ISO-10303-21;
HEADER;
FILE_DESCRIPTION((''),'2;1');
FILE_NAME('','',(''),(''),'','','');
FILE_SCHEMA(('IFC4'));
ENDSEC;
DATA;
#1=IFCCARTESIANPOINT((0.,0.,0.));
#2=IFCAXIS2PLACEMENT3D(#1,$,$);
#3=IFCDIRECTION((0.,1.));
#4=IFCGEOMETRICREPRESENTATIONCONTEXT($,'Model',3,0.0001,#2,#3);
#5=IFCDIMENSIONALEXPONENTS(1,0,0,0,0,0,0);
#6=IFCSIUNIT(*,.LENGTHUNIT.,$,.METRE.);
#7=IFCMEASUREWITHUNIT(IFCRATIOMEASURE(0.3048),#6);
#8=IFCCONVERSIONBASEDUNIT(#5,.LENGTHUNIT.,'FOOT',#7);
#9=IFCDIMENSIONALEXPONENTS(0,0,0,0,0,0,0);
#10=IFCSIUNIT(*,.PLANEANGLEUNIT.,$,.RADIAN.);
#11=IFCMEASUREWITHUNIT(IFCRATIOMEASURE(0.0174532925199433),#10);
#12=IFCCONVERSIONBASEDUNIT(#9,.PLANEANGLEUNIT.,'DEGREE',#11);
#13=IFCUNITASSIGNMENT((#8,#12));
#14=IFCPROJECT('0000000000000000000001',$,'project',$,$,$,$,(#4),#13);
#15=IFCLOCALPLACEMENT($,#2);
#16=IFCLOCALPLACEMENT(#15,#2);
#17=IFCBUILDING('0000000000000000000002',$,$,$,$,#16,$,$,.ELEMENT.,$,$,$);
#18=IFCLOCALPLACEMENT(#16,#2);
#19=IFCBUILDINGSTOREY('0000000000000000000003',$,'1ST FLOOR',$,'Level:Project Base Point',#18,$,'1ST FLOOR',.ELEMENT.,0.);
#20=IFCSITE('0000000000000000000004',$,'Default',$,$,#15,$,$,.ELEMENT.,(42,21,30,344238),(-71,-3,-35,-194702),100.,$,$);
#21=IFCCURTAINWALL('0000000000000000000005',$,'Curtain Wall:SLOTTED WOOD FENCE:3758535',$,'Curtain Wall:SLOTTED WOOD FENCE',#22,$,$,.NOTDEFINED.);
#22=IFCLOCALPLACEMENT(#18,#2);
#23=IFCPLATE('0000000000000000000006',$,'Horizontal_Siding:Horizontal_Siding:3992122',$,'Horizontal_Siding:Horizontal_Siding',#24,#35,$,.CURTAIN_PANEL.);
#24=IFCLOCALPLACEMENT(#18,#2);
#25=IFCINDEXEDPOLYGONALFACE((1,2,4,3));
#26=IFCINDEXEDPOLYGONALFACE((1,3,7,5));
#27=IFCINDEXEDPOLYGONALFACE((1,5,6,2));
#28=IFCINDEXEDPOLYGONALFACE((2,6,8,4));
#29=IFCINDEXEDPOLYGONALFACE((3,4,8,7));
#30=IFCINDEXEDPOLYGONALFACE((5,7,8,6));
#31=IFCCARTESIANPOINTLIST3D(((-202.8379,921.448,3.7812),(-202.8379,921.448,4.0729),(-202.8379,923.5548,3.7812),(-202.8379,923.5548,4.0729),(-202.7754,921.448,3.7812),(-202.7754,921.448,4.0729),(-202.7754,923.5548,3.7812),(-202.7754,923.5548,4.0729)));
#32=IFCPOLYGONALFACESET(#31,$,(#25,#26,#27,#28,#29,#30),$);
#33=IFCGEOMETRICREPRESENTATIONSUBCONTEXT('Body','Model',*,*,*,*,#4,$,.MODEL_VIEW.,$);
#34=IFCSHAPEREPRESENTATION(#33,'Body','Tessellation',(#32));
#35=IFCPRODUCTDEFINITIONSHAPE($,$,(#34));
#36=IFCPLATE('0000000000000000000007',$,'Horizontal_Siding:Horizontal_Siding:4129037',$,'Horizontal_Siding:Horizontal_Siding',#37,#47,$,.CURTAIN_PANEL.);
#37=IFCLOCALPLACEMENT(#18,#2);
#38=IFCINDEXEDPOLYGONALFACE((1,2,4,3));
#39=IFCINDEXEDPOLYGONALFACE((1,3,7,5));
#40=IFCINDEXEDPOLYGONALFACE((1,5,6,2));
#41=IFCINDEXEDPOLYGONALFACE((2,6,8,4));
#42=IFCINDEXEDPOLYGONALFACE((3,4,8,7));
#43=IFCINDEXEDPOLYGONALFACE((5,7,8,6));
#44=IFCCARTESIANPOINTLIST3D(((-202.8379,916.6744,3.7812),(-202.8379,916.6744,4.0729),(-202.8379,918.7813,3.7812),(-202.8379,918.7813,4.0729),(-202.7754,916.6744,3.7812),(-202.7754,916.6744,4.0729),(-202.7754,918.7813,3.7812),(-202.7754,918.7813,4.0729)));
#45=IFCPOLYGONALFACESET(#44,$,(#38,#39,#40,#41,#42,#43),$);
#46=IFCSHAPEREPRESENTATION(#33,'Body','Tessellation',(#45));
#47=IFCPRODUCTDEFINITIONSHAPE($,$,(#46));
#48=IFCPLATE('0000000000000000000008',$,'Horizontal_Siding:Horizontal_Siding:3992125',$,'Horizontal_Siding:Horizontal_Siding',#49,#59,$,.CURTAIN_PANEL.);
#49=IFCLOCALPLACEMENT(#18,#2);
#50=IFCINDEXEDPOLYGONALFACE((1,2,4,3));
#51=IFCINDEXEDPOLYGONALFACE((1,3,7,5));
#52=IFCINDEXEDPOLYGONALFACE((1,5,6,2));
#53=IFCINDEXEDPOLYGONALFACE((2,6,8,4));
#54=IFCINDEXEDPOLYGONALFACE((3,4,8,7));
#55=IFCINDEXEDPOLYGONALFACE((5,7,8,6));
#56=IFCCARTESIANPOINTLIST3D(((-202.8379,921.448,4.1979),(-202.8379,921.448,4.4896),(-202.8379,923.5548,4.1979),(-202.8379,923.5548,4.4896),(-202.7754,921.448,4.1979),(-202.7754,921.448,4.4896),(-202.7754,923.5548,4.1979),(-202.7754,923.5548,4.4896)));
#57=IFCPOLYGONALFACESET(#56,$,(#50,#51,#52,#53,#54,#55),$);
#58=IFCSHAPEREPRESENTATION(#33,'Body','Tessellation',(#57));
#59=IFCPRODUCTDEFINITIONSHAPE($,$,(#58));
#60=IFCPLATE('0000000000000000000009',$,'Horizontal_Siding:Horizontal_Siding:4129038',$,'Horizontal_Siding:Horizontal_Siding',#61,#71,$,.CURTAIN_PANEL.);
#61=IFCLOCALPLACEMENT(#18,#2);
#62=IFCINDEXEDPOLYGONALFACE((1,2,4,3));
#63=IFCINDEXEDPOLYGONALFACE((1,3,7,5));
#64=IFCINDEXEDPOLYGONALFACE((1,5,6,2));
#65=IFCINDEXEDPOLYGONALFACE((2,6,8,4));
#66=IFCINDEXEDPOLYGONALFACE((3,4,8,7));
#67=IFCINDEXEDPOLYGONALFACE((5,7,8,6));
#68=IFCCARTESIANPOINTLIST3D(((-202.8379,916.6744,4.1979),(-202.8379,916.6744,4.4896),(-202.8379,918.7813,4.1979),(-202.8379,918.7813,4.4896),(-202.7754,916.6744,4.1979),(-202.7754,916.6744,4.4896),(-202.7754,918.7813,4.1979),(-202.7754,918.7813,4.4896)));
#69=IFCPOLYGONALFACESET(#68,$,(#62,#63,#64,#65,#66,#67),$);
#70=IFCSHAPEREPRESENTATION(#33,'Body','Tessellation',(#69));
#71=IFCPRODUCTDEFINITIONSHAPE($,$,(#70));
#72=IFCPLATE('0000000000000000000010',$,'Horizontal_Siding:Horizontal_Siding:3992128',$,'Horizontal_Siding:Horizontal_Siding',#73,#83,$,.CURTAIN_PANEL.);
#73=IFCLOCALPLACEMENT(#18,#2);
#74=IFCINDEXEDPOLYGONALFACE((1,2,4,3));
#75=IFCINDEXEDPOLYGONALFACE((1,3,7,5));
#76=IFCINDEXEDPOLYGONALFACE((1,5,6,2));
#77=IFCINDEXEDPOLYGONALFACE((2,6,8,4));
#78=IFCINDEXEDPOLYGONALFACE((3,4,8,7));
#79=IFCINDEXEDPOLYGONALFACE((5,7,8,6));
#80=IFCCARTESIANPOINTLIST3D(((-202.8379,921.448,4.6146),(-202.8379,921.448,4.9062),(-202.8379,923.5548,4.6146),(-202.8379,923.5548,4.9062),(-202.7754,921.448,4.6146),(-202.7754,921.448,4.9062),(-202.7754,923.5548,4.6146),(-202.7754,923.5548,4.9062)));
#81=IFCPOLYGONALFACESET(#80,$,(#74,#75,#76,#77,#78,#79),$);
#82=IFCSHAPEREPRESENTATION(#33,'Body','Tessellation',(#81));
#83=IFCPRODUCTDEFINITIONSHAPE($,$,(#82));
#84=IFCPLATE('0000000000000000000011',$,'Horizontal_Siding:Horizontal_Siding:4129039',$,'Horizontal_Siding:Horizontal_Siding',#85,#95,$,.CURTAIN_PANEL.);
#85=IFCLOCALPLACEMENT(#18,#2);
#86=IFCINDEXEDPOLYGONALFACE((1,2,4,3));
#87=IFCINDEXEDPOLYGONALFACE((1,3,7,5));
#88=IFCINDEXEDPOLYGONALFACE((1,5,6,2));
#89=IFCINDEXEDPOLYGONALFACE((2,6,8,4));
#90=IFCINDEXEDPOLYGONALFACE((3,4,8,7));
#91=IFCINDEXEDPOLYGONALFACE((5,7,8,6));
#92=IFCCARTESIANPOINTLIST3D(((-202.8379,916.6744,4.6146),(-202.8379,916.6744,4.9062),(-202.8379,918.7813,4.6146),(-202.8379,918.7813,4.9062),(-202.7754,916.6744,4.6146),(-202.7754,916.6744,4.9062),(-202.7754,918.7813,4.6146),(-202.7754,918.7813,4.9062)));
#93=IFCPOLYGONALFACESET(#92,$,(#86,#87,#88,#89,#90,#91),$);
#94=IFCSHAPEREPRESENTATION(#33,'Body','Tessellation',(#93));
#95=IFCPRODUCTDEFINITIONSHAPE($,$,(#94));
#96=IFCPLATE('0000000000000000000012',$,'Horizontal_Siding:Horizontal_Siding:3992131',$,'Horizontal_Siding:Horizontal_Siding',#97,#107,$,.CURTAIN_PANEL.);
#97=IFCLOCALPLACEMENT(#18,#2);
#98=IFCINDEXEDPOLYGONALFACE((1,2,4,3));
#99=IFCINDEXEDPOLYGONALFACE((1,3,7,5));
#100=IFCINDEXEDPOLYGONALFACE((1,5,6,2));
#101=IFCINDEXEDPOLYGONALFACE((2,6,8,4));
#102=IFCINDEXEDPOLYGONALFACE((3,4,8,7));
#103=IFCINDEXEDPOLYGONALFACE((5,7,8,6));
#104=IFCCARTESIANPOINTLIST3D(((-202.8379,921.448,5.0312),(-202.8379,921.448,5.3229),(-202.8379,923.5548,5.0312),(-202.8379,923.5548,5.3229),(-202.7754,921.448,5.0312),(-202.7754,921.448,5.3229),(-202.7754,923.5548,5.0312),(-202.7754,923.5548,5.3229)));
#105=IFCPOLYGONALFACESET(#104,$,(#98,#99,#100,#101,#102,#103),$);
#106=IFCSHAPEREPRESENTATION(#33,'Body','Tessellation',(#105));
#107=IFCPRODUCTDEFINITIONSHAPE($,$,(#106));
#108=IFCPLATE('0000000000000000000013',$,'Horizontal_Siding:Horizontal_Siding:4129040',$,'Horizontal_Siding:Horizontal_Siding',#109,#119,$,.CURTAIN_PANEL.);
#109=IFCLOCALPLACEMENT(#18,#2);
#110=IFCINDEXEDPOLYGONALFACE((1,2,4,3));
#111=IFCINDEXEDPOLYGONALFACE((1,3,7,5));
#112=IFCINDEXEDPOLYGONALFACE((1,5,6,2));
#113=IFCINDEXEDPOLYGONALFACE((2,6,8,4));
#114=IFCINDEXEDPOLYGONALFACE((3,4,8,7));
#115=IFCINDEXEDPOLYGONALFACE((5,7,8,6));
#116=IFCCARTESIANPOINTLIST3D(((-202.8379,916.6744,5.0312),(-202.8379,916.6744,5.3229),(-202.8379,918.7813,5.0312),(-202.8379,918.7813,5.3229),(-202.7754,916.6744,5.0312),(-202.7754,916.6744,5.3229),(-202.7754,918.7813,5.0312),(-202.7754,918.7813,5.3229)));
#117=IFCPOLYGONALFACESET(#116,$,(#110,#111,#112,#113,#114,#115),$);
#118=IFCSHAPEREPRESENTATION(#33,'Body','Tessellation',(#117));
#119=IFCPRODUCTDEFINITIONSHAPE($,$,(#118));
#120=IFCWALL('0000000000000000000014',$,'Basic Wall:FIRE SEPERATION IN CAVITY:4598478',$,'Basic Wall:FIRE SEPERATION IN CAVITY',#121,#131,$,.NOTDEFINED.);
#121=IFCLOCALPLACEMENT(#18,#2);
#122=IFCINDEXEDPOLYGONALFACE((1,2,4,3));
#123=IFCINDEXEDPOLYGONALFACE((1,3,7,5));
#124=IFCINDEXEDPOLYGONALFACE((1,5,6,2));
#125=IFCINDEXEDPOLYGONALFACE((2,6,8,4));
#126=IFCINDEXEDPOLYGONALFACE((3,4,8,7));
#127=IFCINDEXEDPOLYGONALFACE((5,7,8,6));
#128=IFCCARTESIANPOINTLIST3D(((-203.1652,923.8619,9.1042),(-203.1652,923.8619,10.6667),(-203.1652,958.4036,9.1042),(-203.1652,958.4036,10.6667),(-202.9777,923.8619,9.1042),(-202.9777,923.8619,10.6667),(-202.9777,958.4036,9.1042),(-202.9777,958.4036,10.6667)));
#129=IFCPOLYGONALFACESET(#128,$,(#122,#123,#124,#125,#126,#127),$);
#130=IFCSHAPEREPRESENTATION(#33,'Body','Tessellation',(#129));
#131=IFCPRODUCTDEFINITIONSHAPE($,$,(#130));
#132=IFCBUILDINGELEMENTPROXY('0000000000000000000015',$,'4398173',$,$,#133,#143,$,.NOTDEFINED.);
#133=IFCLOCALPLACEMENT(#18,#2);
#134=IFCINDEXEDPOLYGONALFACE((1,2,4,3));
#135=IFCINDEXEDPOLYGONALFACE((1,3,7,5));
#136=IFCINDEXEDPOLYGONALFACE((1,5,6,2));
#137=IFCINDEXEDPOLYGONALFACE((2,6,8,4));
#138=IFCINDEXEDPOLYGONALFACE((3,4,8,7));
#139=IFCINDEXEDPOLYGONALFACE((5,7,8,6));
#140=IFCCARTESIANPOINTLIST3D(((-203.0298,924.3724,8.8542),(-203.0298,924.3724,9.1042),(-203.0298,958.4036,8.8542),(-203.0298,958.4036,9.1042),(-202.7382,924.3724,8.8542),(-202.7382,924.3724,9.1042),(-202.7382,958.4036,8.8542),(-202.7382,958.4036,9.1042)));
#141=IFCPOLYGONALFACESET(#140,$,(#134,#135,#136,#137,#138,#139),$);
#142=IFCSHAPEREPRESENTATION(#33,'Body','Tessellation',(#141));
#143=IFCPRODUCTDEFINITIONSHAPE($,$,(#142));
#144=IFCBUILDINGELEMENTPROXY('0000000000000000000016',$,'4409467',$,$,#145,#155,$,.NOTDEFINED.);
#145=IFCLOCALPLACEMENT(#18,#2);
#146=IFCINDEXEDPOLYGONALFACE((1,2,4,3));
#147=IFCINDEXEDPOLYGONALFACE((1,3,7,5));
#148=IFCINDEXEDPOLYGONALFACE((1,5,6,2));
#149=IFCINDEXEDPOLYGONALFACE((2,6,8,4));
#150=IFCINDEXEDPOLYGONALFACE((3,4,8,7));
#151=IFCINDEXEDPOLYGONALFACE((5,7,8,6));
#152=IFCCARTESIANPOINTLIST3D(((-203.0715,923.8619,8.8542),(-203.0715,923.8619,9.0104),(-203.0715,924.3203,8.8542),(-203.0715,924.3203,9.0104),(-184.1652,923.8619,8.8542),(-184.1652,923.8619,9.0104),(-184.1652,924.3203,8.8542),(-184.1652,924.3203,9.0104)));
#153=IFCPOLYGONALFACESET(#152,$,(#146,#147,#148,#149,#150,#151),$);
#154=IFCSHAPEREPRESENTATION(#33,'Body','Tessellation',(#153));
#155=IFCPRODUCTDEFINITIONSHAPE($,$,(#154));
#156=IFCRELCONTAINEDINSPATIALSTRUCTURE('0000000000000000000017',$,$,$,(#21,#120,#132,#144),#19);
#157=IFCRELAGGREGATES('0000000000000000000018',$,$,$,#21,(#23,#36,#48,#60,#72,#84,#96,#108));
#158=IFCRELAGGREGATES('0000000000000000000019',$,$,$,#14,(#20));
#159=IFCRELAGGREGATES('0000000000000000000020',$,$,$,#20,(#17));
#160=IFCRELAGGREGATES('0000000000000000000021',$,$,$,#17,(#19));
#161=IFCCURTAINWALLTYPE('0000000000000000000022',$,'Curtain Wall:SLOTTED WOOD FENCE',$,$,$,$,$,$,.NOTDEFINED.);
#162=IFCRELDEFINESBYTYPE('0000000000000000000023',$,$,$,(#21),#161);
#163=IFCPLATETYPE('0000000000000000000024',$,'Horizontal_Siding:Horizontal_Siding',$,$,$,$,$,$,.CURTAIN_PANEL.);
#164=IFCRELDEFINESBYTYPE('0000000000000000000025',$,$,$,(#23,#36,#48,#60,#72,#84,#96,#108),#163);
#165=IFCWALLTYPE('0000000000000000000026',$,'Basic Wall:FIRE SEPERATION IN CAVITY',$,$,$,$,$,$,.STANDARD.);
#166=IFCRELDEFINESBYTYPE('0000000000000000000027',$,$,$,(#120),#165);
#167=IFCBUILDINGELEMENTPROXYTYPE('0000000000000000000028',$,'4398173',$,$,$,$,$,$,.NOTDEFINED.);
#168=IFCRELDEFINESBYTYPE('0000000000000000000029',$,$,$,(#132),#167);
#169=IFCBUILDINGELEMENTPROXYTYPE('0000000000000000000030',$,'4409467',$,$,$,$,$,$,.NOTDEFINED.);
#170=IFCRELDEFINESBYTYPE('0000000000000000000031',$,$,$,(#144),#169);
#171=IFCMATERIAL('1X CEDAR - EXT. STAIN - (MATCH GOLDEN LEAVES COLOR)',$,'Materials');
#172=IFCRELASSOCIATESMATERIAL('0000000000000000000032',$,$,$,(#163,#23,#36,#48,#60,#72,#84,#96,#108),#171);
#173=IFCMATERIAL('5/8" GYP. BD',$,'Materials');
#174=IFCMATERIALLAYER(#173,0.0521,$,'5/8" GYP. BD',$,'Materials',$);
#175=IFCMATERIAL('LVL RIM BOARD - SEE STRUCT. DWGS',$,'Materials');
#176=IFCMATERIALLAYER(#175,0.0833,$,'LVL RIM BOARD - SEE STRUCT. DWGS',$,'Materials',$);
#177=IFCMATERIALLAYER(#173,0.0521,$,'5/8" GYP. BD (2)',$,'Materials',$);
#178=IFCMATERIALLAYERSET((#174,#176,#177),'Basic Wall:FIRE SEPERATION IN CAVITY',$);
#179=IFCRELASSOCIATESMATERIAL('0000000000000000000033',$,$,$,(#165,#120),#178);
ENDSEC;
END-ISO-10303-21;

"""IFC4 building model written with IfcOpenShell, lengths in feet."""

from ifc_helpers import new_model, entity, si_unit, converted_unit, direction, frame, frame_2d, origin, origin_2d_with_axis, place, context, subcontext, project, spatial, rectangle, extrude, source, transform, mapped, material, layer, layer_set, layer_usage, type_object, type_shapes, element, aggregate, save


model = new_model("IFC4")

# Units and contexts
model_context = context("Model", 3, precision=0.0001, world=origin(), true_north=direction((0.0, 1.0)))
body_context = subcontext(model_context, "Body", "Model", "MODEL_VIEW")
ifc_project = project(units=[converted_unit("LENGTHUNIT", "FOOT", entity("IfcRatioMeasure", 0.3048), si_unit("LENGTHUNIT", "METRE"), dimensions=[1, 0, 0, 0, 0, 0, 0]), converted_unit("PLANEANGLEUNIT", "DEGREE", entity("IfcRatioMeasure", 0.0174532925199433), si_unit("PLANEANGLEUNIT", "RADIAN"), dimensions=[0, 0, 0, 0, 0, 0, 0])], contexts=[model_context])

# Site, building, storey
site_placement = place(None, origin())
site = spatial("IfcSite", under=ifc_project, at=site_placement, Name="Default", CompositionType="ELEMENT", RefLatitude=(42, 21, 30, 344238), RefLongitude=(-71, -3, -35, -194702), RefElevation=100.0)
building_placement = place(site_placement, origin())
building = spatial("IfcBuilding", under=site, at=building_placement, CompositionType="ELEMENT")
storey_placement = place(building_placement, origin())
storey = spatial("IfcBuildingStorey", under=building, at=storey_placement, Name="1ST FLOOR", ObjectType="Level:Project Base Point", LongName="1ST FLOOR", CompositionType="ELEMENT", Elevation=0.0)

# Curtain wall, plates
curtain_wall_type = type_object("IfcCurtainWallType", Name="Curtain Wall:SLOTTED WOOD FENCE", PredefinedType="NOTDEFINED")
curtain_wall_placement = place(storey_placement, origin())
curtain_wall = element("IfcCurtainWall", 1, at=curtain_wall_placement, inside=storey, type_object=curtain_wall_type, Name="Curtain Wall:SLOTTED WOOD FENCE:3758535", ObjectType="Curtain Wall:SLOTTED WOOD FENCE", PredefinedType="NOTDEFINED")
ifc_material_1 = material(Name="1X CEDAR - EXT. STAIN - (MATCH GOLDEN LEAVES COLOR)", Category="Materials")
plate_type_1 = type_object("IfcPlateType", Name="Horizontal_Siding:Horizontal_Siding", PredefinedType="CURTAIN_PANEL", material=ifc_material_1)
shared_shape_1 = source(origin(), body_context, "Body", "SweptSolid", [
    extrude(rectangle(XDim=0.0625, YDim=2.1069, at=origin_2d_with_axis()), frame((1.0534, 0.0312, 0.0), z_axis=(0.0, 0.0, 1.0), x_axis=(0.0, 1.0, 0.0)), (0.0, 0.0, 1.0), 0.2917),
])
type_shapes(plate_type_1, [shared_shape_1])
plate_1_placement = place(curtain_wall_placement, frame((-202.8379, 923.5548, 3.7812), z_axis=(0.0, 0.0, 1.0), x_axis=(0.0, -1.0, 0.0)))
plate_1 = element("IfcPlate", 2, at=plate_1_placement, type_object=plate_type_1, material=ifc_material_1, Name="Horizontal_Siding:Horizontal_Siding:3992122", ObjectType="Horizontal_Siding:Horizontal_Siding", PredefinedType="CURTAIN_PANEL", context=body_context, shape_type="MappedRepresentation", body=[
    mapped(shared_shape_1, transform((0.0, 0.0, 0.0), scale=1.0)),
])
plate_2_placement = place(curtain_wall_placement, frame((-202.8379, 918.7813, 3.7812), z_axis=(0.0, 0.0, 1.0), x_axis=(0.0, -1.0, 0.0)))
plate_2 = element("IfcPlate", 3, at=plate_2_placement, type_object=plate_type_1, material=ifc_material_1, Name="Horizontal_Siding:Horizontal_Siding:4129037", ObjectType="Horizontal_Siding:Horizontal_Siding", PredefinedType="CURTAIN_PANEL", context=body_context, shape_type="MappedRepresentation", body=[
    mapped(shared_shape_1, transform((0.0, 0.0, 0.0), scale=1.0)),
])
plate_3_placement = place(curtain_wall_placement, frame((-202.8379, 923.5548, 4.1979), z_axis=(0.0, 0.0, 1.0), x_axis=(0.0, -1.0, 0.0)))
plate_3 = element("IfcPlate", 4, at=plate_3_placement, type_object=plate_type_1, material=ifc_material_1, Name="Horizontal_Siding:Horizontal_Siding:3992125", ObjectType="Horizontal_Siding:Horizontal_Siding", PredefinedType="CURTAIN_PANEL", context=body_context, shape_type="MappedRepresentation", body=[
    mapped(shared_shape_1, transform((0.0, 0.0, 0.0), scale=1.0)),
])
plate_4_placement = place(curtain_wall_placement, frame((-202.8379, 918.7813, 4.1979), z_axis=(0.0, 0.0, 1.0), x_axis=(0.0, -1.0, 0.0)))
plate_4 = element("IfcPlate", 5, at=plate_4_placement, type_object=plate_type_1, material=ifc_material_1, Name="Horizontal_Siding:Horizontal_Siding:4129038", ObjectType="Horizontal_Siding:Horizontal_Siding", PredefinedType="CURTAIN_PANEL", context=body_context, shape_type="MappedRepresentation", body=[
    mapped(shared_shape_1, transform((0.0, 0.0, 0.0), scale=1.0)),
])
plate_5_placement = place(curtain_wall_placement, frame((-202.8379, 923.5548, 4.6146), z_axis=(0.0, 0.0, 1.0), x_axis=(0.0, -1.0, 0.0)))
plate_5 = element("IfcPlate", 6, at=plate_5_placement, type_object=plate_type_1, material=ifc_material_1, Name="Horizontal_Siding:Horizontal_Siding:3992128", ObjectType="Horizontal_Siding:Horizontal_Siding", PredefinedType="CURTAIN_PANEL", context=body_context, shape_type="MappedRepresentation", body=[
    mapped(shared_shape_1, transform((0.0, 0.0, 0.0), scale=1.0)),
])
plate_6_placement = place(curtain_wall_placement, frame((-202.8379, 918.7813, 4.6146), z_axis=(0.0, 0.0, 1.0), x_axis=(0.0, -1.0, 0.0)))
plate_6 = element("IfcPlate", 7, at=plate_6_placement, type_object=plate_type_1, material=ifc_material_1, Name="Horizontal_Siding:Horizontal_Siding:4129039", ObjectType="Horizontal_Siding:Horizontal_Siding", PredefinedType="CURTAIN_PANEL", context=body_context, shape_type="MappedRepresentation", body=[
    mapped(shared_shape_1, transform((0.0, 0.0, 0.0), scale=1.0)),
])
plate_7_placement = place(curtain_wall_placement, frame((-202.8379, 923.5548, 5.0312), z_axis=(0.0, 0.0, 1.0), x_axis=(0.0, -1.0, 0.0)))
plate_7 = element("IfcPlate", 8, at=plate_7_placement, type_object=plate_type_1, material=ifc_material_1, Name="Horizontal_Siding:Horizontal_Siding:3992131", ObjectType="Horizontal_Siding:Horizontal_Siding", PredefinedType="CURTAIN_PANEL", context=body_context, shape_type="MappedRepresentation", body=[
    mapped(shared_shape_1, transform((0.0, 0.0, 0.0), scale=1.0)),
])
plate_8_placement = place(curtain_wall_placement, frame((-202.8379, 918.7813, 5.0312), z_axis=(0.0, 0.0, 1.0), x_axis=(0.0, -1.0, 0.0)))
plate_8 = element("IfcPlate", 9, at=plate_8_placement, type_object=plate_type_1, material=ifc_material_1, Name="Horizontal_Siding:Horizontal_Siding:4129040", ObjectType="Horizontal_Siding:Horizontal_Siding", PredefinedType="CURTAIN_PANEL", context=body_context, shape_type="MappedRepresentation", body=[
    mapped(shared_shape_1, transform((0.0, 0.0, 0.0), scale=1.0)),
])
aggregate(curtain_wall, [plate_1, plate_2, plate_3, plate_4, plate_5, plate_6, plate_7, plate_8])

# Wall
ifc_material_2 = material(Name="5/8\" GYP. BD", Category="Materials")
ifc_layer_1 = layer(ifc_material_2, 0.0521, Name="5/8\" GYP. BD", Category="Materials")
ifc_material_3 = material(Name="LVL RIM BOARD - SEE STRUCT. DWGS", Category="Materials")
ifc_layer_2 = layer(ifc_material_3, 0.0833, Name="LVL RIM BOARD - SEE STRUCT. DWGS", Category="Materials")
ifc_layer_3 = layer(ifc_material_2, 0.0521, Name="5/8\" GYP. BD (2)", Category="Materials")
ifc_layer_set = layer_set([ifc_layer_1, ifc_layer_2, ifc_layer_3], Name="Basic Wall:FIRE SEPERATION IN CAVITY")
ifc_layer_usage = layer_usage(ifc_layer_set, "AXIS2", "POSITIVE", -0.0938)
wall_type = type_object("IfcWallType", Name="Basic Wall:FIRE SEPERATION IN CAVITY", PredefinedType="STANDARD", material=ifc_layer_set)
wall_placement = place(storey_placement, frame((-203.0715, 923.8619, 9.1042), z_axis=(0.0, 0.0, 1.0), x_axis=(0.0, 1.0, 0.0)))
element("IfcWall", 10, at=wall_placement, inside=storey, type_object=wall_type, material=ifc_layer_usage, Name="Basic Wall:FIRE SEPERATION IN CAVITY:4598478", ObjectType="Basic Wall:FIRE SEPERATION IN CAVITY", PredefinedType="NOTDEFINED", context=body_context, shape_type="SweptSolid", body=[
    extrude(rectangle(XDim=34.5417, YDim=0.1875, at=frame_2d((17.2708, 0.0), x_axis=(-1.0, 0.0))), origin(), (0.0, 0.0, 1.0), 1.5625),
])

# Building element proxies
building_element_proxy_type_1 = type_object("IfcBuildingElementProxyType", Name="4398173", PredefinedType="NOTDEFINED")
proxy_1_placement = place(storey_placement, frame((-203.0298, 924.3724, 8.8542)))
element("IfcBuildingElementProxy", 11, at=proxy_1_placement, inside=storey, type_object=building_element_proxy_type_1, Name="4398173", PredefinedType="NOTDEFINED", context=body_context, shape_type="SweptSolid", body=[
    extrude(rectangle(XDim=34.0313, YDim=0.2917, at=frame_2d((0.0, 0.0), x_axis=(1.0, 0.0))), frame((0.1458, 17.0156, 0.0), z_axis=(0.0, 0.0, 1.0), x_axis=(0.0, 1.0, 0.0)), (0.0, 0.0, 1.0), 0.25),
])
building_element_proxy_type_2 = type_object("IfcBuildingElementProxyType", Name="4409467", PredefinedType="NOTDEFINED")
proxy_2_placement = place(storey_placement, frame((-203.0715, 923.8619, 8.8542)))
element("IfcBuildingElementProxy", 12, at=proxy_2_placement, inside=storey, type_object=building_element_proxy_type_2, Name="4409467", PredefinedType="NOTDEFINED", context=body_context, shape_type="SweptSolid", body=[
    extrude(rectangle(XDim=18.9063, YDim=0.4583, at=frame_2d((0.0, 0.0), x_axis=(1.0, 0.0))), frame((9.4531, 0.2292, 0.0), z_axis=(0.0, 0.0, 1.0), x_axis=(-1.0, 0.0, 0.0)), (0.0, 0.0, 1.0), 0.1562),
])

save(model, "model.ifc")
